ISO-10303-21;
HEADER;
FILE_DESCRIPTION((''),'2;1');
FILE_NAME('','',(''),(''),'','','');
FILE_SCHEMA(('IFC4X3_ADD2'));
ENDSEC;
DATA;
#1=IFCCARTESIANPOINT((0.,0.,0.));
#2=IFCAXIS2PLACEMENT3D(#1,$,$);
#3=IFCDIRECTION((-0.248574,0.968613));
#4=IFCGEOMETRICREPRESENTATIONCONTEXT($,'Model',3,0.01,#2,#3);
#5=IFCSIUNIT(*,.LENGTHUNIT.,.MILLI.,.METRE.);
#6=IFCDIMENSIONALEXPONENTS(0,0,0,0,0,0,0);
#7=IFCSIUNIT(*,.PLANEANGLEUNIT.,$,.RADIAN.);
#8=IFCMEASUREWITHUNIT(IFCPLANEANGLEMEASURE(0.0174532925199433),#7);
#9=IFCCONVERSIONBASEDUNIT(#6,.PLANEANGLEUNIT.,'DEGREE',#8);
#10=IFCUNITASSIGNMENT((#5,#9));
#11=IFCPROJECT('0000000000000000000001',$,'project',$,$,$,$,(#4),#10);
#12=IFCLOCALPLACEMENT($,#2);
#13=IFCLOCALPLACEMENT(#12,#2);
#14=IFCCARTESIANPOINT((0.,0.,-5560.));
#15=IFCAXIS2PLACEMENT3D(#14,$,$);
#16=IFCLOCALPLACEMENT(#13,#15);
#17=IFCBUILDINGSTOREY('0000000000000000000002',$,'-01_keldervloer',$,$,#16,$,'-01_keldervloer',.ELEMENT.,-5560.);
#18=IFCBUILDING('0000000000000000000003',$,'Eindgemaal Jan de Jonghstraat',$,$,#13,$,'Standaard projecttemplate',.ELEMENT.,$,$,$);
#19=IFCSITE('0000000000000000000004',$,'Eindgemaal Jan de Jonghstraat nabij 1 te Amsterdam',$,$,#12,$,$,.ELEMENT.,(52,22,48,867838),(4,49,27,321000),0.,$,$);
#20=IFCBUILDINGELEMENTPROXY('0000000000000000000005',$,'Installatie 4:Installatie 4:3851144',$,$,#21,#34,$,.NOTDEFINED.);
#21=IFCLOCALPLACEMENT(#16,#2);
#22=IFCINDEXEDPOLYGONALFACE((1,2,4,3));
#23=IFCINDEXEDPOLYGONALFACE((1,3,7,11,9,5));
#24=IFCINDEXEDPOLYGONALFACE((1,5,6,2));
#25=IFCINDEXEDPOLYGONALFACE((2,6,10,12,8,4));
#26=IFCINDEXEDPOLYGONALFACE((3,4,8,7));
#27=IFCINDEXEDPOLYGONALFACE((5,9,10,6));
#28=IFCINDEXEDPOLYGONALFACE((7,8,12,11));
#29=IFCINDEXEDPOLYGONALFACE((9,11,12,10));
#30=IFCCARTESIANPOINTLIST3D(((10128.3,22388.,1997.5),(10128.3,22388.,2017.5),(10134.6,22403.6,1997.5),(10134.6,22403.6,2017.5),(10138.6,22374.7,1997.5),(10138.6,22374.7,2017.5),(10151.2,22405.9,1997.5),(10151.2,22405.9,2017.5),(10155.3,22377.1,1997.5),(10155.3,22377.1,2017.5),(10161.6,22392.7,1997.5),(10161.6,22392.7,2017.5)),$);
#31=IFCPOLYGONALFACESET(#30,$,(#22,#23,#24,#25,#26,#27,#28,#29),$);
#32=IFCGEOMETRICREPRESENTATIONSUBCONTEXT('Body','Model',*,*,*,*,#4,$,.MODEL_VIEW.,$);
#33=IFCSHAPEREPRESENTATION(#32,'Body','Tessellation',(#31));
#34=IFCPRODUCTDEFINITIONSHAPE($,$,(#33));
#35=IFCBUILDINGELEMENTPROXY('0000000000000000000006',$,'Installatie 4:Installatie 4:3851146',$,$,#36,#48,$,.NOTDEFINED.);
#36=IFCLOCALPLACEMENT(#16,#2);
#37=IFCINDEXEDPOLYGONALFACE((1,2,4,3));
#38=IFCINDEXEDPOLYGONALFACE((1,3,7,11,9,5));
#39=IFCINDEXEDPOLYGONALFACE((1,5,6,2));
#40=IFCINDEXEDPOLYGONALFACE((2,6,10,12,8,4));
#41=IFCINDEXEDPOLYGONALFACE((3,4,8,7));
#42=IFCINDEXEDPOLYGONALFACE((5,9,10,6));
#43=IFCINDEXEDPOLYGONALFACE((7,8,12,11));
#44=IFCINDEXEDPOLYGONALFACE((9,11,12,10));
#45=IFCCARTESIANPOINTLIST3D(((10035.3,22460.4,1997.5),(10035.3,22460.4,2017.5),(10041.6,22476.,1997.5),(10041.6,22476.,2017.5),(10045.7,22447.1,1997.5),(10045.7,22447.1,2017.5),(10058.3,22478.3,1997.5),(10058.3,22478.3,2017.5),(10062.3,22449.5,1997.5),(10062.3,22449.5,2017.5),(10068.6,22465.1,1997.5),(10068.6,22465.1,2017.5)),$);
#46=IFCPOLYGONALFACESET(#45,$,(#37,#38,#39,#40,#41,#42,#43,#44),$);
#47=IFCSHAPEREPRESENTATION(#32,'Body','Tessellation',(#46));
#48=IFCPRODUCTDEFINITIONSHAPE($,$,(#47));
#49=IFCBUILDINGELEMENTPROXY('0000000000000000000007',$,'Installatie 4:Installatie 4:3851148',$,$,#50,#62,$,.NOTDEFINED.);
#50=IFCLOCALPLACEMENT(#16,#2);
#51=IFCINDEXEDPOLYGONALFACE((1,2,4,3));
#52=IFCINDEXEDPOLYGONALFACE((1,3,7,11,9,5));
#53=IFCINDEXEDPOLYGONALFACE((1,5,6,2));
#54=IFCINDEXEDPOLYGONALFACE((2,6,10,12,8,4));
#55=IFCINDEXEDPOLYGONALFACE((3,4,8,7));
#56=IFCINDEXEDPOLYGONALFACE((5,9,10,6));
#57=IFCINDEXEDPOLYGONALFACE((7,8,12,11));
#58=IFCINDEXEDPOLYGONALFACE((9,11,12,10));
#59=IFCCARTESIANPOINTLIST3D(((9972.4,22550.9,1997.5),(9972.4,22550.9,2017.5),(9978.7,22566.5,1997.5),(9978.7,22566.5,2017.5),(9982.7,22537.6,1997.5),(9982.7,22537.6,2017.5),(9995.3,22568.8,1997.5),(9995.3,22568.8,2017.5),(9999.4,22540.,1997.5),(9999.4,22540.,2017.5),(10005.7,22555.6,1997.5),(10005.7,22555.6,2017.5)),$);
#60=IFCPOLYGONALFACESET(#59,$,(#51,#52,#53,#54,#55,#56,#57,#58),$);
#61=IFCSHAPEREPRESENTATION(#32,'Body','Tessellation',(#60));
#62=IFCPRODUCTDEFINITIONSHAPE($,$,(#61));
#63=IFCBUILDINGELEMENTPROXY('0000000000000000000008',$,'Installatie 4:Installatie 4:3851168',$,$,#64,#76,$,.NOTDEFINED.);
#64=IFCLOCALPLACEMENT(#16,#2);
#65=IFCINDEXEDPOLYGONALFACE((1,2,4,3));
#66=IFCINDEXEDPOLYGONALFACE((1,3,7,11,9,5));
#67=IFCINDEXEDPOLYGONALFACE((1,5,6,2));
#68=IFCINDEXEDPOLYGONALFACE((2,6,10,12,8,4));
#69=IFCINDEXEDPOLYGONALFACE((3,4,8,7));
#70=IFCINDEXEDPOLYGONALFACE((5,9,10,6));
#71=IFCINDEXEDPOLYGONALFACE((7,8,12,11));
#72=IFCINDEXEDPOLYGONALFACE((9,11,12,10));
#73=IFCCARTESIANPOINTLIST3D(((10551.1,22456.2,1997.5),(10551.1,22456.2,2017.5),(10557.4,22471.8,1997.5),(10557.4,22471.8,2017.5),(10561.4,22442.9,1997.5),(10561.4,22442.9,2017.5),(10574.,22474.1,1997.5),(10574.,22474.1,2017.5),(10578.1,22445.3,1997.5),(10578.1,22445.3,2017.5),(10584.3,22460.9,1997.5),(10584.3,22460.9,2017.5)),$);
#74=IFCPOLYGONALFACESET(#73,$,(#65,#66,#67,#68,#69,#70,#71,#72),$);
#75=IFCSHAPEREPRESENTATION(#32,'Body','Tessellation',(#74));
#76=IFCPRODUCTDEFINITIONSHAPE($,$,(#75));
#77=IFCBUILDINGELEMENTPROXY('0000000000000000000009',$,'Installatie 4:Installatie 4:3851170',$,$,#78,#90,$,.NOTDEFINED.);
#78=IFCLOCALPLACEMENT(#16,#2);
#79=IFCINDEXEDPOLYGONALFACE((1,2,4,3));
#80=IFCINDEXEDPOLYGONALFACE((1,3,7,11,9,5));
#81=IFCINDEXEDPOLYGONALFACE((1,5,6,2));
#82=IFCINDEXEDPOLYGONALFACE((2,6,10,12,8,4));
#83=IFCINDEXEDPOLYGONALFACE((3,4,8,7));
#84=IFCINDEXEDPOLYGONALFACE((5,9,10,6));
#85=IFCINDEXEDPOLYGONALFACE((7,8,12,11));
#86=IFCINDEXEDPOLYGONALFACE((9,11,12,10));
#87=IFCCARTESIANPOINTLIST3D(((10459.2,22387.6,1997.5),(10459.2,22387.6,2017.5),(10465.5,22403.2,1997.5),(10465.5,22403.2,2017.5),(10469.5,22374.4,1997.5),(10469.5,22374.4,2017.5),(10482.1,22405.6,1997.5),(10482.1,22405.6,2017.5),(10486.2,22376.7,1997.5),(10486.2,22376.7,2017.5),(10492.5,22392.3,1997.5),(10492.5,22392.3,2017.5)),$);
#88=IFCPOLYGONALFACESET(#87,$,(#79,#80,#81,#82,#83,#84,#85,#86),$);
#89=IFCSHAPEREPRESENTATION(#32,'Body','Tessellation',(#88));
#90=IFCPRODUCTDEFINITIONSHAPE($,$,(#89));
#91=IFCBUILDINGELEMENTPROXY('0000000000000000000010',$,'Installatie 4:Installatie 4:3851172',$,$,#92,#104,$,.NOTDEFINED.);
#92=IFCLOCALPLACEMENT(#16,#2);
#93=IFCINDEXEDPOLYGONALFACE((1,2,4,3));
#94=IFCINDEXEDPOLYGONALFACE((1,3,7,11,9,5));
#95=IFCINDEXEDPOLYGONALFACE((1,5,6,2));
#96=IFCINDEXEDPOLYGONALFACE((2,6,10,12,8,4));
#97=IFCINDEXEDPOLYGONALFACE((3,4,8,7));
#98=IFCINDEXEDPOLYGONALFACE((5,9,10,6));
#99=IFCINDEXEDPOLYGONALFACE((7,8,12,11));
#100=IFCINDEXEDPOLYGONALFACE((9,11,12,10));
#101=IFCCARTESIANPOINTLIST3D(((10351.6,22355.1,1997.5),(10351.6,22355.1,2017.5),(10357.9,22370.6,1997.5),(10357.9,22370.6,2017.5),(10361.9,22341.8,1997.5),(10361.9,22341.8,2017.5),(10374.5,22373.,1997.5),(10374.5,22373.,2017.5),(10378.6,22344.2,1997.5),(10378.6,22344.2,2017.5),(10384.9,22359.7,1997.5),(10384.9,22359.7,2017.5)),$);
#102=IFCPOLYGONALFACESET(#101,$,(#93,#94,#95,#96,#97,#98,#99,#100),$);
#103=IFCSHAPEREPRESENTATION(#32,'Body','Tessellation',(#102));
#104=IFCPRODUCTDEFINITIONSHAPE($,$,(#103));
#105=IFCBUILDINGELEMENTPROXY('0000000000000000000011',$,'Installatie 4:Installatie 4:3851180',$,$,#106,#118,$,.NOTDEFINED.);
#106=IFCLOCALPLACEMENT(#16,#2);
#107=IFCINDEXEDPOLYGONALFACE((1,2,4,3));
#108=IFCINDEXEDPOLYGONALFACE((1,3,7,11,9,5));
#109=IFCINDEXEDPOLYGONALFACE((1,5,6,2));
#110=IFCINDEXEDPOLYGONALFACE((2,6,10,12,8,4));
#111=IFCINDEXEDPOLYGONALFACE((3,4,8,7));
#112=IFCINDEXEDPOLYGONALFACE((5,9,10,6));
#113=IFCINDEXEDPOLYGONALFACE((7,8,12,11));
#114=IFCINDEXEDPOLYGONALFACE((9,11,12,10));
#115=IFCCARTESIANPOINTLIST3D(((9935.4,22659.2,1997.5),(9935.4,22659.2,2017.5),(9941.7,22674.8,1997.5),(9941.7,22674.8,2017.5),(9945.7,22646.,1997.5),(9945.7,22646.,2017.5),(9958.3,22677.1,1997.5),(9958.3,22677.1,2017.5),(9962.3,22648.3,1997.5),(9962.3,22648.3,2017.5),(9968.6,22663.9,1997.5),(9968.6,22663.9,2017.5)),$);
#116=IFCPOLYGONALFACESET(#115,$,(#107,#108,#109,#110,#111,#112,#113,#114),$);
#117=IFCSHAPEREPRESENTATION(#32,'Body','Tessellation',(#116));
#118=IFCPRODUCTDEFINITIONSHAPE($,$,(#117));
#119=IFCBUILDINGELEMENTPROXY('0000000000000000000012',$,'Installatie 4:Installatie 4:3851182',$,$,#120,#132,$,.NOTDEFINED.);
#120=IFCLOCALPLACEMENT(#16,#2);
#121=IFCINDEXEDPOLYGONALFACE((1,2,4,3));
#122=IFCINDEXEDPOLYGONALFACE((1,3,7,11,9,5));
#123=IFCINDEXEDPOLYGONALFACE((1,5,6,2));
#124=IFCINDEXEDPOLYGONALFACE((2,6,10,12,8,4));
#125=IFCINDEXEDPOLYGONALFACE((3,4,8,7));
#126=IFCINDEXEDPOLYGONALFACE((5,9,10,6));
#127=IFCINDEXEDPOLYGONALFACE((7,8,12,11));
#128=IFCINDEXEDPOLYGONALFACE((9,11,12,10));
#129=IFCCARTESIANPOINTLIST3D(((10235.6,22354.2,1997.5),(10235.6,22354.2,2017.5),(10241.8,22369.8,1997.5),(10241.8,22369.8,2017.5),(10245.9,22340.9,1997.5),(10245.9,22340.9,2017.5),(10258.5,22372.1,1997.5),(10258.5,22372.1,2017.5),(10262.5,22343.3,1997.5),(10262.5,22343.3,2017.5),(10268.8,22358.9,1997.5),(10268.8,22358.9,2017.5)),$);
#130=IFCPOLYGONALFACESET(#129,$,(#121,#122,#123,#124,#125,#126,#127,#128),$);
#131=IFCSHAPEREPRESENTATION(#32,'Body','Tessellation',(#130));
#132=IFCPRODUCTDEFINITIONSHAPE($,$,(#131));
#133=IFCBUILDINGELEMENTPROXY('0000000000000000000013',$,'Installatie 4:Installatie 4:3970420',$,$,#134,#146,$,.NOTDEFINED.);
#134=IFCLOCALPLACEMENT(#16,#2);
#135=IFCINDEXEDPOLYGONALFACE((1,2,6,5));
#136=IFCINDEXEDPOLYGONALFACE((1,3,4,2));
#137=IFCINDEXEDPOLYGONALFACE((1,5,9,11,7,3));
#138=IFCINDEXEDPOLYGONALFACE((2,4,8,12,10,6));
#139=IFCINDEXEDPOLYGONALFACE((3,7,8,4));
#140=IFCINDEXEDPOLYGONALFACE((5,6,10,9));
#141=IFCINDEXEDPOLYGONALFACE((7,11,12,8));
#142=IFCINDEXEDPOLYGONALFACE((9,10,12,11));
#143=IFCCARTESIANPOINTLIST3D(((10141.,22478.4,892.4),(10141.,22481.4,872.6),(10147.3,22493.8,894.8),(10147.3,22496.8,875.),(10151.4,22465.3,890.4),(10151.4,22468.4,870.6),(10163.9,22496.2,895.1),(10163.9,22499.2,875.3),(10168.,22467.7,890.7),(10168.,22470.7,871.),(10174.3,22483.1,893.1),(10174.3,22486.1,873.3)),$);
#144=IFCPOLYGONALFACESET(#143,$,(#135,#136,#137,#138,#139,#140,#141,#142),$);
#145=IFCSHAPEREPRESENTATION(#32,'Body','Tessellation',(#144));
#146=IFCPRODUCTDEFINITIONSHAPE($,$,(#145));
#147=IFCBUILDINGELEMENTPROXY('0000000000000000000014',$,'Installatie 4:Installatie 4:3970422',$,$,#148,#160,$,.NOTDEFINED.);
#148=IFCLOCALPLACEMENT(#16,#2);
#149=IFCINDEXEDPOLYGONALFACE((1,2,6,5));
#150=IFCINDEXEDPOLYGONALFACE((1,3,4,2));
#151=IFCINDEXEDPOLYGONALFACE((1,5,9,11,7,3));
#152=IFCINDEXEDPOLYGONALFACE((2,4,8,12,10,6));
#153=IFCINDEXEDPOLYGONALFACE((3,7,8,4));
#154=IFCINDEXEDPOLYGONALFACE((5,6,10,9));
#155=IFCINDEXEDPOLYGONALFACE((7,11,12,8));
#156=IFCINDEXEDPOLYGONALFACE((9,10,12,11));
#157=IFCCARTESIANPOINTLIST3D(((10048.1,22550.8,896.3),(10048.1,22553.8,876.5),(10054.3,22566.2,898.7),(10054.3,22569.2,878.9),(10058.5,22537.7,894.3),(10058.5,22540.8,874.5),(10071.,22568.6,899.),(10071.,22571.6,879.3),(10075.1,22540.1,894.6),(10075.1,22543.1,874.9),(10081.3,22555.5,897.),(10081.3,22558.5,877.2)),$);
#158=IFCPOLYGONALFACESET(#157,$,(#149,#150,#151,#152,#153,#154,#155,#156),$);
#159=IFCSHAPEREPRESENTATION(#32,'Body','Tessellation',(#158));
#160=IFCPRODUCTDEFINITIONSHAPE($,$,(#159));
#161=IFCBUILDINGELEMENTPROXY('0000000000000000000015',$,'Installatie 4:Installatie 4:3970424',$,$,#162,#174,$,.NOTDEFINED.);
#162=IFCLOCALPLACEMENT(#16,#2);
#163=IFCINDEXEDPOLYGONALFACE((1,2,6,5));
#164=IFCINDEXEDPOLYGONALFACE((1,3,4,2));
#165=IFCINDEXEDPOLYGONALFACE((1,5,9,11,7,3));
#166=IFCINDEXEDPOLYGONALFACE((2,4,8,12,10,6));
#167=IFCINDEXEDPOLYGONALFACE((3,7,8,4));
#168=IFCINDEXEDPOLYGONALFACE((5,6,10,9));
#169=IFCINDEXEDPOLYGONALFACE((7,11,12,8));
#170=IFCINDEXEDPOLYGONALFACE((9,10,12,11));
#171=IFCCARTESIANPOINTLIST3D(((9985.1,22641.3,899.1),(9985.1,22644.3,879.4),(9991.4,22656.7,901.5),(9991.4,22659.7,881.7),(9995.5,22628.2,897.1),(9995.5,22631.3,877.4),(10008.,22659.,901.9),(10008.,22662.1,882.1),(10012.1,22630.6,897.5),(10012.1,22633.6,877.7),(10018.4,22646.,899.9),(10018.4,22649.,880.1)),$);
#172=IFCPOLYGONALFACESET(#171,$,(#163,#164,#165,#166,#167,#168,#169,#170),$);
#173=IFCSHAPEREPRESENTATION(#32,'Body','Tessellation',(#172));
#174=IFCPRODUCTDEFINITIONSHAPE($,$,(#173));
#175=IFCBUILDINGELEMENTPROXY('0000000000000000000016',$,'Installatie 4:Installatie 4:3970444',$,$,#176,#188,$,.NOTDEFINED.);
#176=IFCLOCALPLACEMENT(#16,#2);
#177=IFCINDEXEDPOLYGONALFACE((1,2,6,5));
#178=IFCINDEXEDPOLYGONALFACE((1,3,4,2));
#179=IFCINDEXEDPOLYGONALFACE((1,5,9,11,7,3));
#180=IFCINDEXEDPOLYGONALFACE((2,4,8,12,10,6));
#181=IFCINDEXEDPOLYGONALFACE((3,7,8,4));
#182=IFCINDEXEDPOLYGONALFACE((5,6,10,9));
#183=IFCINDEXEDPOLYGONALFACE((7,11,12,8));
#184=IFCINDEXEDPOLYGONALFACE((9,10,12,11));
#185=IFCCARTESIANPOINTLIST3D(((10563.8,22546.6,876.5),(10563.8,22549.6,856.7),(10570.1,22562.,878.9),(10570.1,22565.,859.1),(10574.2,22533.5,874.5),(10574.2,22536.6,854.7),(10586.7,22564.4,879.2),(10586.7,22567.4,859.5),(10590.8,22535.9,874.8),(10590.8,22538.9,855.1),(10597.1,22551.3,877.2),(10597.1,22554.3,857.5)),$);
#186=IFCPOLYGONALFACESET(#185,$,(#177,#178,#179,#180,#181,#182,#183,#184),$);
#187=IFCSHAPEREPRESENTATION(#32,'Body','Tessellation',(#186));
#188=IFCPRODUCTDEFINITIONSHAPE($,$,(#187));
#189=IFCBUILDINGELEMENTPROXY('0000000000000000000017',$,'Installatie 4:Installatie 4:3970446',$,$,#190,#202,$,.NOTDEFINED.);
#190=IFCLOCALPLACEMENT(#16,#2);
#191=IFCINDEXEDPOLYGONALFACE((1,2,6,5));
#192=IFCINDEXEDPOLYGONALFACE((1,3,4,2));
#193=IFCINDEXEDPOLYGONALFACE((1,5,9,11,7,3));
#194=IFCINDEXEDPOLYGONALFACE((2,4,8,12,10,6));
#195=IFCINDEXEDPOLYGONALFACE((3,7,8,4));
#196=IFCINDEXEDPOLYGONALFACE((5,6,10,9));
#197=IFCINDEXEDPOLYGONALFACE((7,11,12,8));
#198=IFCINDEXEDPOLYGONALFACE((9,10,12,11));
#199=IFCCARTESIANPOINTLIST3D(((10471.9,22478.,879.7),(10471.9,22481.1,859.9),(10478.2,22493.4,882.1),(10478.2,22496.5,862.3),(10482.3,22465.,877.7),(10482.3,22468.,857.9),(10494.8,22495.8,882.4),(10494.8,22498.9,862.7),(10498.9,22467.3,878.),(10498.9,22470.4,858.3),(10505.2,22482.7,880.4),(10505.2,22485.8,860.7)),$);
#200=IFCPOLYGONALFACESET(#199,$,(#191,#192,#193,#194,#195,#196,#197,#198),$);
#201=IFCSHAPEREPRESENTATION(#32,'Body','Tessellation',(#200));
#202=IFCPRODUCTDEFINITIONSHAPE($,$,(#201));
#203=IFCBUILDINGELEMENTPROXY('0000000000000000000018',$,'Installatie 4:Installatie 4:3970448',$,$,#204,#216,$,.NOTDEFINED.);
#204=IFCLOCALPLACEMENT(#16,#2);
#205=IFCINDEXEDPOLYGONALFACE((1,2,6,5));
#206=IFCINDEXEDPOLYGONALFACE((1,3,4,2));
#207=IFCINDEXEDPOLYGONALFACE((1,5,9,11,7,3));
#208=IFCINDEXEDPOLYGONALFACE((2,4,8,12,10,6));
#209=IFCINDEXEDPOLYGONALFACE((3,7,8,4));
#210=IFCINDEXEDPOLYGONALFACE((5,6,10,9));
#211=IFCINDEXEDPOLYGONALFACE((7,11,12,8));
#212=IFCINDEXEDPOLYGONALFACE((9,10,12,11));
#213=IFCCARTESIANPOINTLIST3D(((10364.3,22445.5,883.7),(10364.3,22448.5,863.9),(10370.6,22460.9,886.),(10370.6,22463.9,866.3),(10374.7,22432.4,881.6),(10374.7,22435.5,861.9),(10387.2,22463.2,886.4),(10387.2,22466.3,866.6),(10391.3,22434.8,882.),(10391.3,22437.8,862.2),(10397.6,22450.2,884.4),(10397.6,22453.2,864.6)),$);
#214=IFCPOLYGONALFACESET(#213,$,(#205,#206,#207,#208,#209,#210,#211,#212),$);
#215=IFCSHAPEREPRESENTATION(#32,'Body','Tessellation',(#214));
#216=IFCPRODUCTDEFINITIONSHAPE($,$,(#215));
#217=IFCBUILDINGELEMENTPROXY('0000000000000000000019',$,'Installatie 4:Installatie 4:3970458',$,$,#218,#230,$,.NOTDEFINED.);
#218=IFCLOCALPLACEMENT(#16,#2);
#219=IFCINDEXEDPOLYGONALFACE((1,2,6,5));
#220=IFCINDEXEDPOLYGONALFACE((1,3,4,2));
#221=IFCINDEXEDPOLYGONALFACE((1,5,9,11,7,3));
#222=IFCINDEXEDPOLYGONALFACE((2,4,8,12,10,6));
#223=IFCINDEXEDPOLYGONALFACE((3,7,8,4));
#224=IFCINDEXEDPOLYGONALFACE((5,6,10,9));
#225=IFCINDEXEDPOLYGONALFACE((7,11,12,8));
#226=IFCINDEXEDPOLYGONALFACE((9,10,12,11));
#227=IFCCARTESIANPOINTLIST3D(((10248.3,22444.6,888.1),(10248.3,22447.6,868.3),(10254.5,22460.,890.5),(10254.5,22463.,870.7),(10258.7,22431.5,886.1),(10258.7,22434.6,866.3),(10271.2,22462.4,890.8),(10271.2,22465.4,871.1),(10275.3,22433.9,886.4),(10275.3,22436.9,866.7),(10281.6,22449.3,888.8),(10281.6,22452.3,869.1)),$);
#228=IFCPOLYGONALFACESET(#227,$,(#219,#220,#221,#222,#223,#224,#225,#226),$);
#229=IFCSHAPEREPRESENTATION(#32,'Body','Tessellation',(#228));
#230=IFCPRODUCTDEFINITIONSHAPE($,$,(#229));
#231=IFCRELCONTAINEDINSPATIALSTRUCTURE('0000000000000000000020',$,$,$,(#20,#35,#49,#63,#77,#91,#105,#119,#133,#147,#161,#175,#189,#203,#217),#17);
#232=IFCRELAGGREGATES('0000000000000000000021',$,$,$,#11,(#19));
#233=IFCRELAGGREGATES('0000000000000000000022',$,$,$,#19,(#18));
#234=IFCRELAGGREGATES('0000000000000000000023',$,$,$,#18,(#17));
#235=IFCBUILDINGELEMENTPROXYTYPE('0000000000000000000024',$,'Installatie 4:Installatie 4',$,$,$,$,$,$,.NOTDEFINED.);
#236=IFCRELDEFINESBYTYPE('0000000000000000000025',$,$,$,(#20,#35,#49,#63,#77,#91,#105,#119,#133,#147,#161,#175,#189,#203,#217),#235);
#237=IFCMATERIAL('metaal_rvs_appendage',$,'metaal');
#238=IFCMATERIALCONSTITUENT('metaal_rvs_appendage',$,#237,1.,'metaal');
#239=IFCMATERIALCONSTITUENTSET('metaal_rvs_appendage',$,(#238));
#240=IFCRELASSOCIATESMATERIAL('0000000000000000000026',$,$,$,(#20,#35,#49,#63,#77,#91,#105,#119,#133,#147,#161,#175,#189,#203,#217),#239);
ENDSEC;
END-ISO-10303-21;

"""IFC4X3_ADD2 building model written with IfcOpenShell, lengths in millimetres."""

from ifc_helpers import new_model, entity, si_unit, converted_unit, direction, frame, origin, place, context, subcontext, project, spatial, polyline, outline, extrude, source, transform, mapped, material, constituent, constituent_set, type_object, type_shapes, element, save


model = new_model("IFC4X3_ADD2")

# Units and contexts
model_context = context("Model", 3, precision=0.01, world=origin(), true_north=direction((-0.248574, 0.968613)))
body_context = subcontext(model_context, "Body", "Model", "MODEL_VIEW")
ifc_project = project(units=[si_unit("LENGTHUNIT", "METRE", prefix="MILLI"), converted_unit("PLANEANGLEUNIT", "DEGREE", entity("IfcPlaneAngleMeasure", 0.0174532925199433), si_unit("PLANEANGLEUNIT", "RADIAN"), dimensions=[0, 0, 0, 0, 0, 0, 0])], contexts=[model_context])

# Site, building, storey
site_placement = place(None, origin())
site = spatial("IfcSite", under=ifc_project, at=site_placement, Name="Eindgemaal Jan de Jonghstraat nabij 1 te Amsterdam", CompositionType="ELEMENT", RefLatitude=(52, 22, 48, 867838), RefLongitude=(4, 49, 27, 321000), RefElevation=0.0)
building_placement = place(site_placement, origin())
building = spatial("IfcBuilding", under=site, at=building_placement, Name="Eindgemaal Jan de Jonghstraat", LongName="Standaard projecttemplate", CompositionType="ELEMENT")
storey_placement = place(building_placement, frame((0.0, 0.0, -5560.0)))
storey = spatial("IfcBuildingStorey", under=building, at=storey_placement, Name="-01_keldervloer", LongName="-01_keldervloer", CompositionType="ELEMENT", Elevation=-5560.0)

# Building element proxies
ifc_material_1 = material(Name="metaal_rvs_appendage", Category="metaal")
ifc_constituent_1 = constituent(ifc_material_1, Name="metaal_rvs_appendage", Category="metaal", fraction=1.0)
ifc_constituent_set_1 = constituent_set(constituents=[ifc_constituent_1], Name="metaal_rvs_appendage")
building_element_proxy_type_1 = type_object("IfcBuildingElementProxyType", Name="Installatie 4:Installatie 4", PredefinedType="NOTDEFINED")
shared_shape_1 = source(origin(), body_context, "Body", "SweptSolid", [
    extrude(outline(polyline([(-8.4, -14.6), (8.4, -14.6), (16.8, 0.0), (8.4, 14.6), (-8.4, 14.6), (-16.8, 0.0), (-8.4, -14.6)])), frame((0.0, 0.0, -11.0), z_axis=(0.0, 0.0, 1.0), x_axis=(0.400458, -0.916315, 0.0)), (0.0, 0.0, 1.0), 20.0),
])
type_shapes(building_element_proxy_type_1, [shared_shape_1])
for number, where, z_axis, x_axis, name in (
    (1, (10144.9, 22390.3, 2008.5), (0.0, 0.0, 1.0), (0.968613, 0.248574, 0.0), "Installatie 4:Installatie 4:3851144"),
    (2, (10052.0, 22462.7, 2008.5), (0.0, 0.0, 1.0), (0.968613, 0.248574, 0.0), "Installatie 4:Installatie 4:3851146"),
    (3, (9989.0, 22553.2, 2008.5), (0.0, 0.0, 1.0), (0.968613, 0.248574, 0.0), "Installatie 4:Installatie 4:3851148"),
    (4, (10567.7, 22458.5, 2008.5), (0.0, 0.0, 1.0), (0.968613, 0.248574, 0.0), "Installatie 4:Installatie 4:3851168"),
    (5, (10475.8, 22390.0, 2008.5), (0.0, 0.0, 1.0), (0.968613, 0.248574, 0.0), "Installatie 4:Installatie 4:3851170"),
    (6, (10368.2, 22357.4, 2008.5), (0.0, 0.0, 1.0), (0.968613, 0.248574, 0.0), "Installatie 4:Installatie 4:3851172"),
    (7, (9952.0, 22661.6, 2008.5), (0.0, 0.0, 1.0), (0.968613, 0.248574, 0.0), "Installatie 4:Installatie 4:3851180"),
    (8, (10252.2, 22356.5, 2008.5), (0.0, 0.0, 1.0), (0.968613, 0.248574, 0.0), "Installatie 4:Installatie 4:3851182"),
    (9, (10157.7, 22482.1, 883.8), (0.0, -0.152404, 0.988318), (0.967902, 0.248392, 0.038303), "Installatie 4:Installatie 4:3970420"),
    (10, (10064.7, 22554.5, 887.8), (0.0, -0.152404, 0.988318), (0.967902, 0.248392, 0.038303), "Installatie 4:Installatie 4:3970422"),
    (11, (10001.8, 22645.0, 890.6), (0.0, -0.152404, 0.988318), (0.967902, 0.248392, 0.038303), "Installatie 4:Installatie 4:3970424"),
    (12, (10580.4, 22550.3, 868.0), (0.0, -0.152404, 0.988318), (0.967902, 0.248392, 0.038303), "Installatie 4:Installatie 4:3970444"),
    (13, (10488.5, 22481.8, 871.2), (0.0, -0.152404, 0.988318), (0.967902, 0.248392, 0.038303), "Installatie 4:Installatie 4:3970446"),
    (14, (10381.0, 22449.2, 875.1), (0.0, -0.152404, 0.988318), (0.967902, 0.248392, 0.038303), "Installatie 4:Installatie 4:3970448"),
    (15, (10264.9, 22448.3, 879.6), (0.0, -0.152404, 0.988318), (0.967902, 0.248392, 0.038303), "Installatie 4:Installatie 4:3970458"),
):
    element("IfcBuildingElementProxy", number, at=place(storey_placement, frame(where, z_axis=z_axis, x_axis=x_axis)), inside=storey, type_object=building_element_proxy_type_1, material=ifc_constituent_set_1, Name=name, PredefinedType="NOTDEFINED", context=body_context, shape_type="MappedRepresentation", body=[
        mapped(shared_shape_1, transform((0.0, 0.0, 0.0), scale=1.0)),
    ])

save(model, "model.ifc")
